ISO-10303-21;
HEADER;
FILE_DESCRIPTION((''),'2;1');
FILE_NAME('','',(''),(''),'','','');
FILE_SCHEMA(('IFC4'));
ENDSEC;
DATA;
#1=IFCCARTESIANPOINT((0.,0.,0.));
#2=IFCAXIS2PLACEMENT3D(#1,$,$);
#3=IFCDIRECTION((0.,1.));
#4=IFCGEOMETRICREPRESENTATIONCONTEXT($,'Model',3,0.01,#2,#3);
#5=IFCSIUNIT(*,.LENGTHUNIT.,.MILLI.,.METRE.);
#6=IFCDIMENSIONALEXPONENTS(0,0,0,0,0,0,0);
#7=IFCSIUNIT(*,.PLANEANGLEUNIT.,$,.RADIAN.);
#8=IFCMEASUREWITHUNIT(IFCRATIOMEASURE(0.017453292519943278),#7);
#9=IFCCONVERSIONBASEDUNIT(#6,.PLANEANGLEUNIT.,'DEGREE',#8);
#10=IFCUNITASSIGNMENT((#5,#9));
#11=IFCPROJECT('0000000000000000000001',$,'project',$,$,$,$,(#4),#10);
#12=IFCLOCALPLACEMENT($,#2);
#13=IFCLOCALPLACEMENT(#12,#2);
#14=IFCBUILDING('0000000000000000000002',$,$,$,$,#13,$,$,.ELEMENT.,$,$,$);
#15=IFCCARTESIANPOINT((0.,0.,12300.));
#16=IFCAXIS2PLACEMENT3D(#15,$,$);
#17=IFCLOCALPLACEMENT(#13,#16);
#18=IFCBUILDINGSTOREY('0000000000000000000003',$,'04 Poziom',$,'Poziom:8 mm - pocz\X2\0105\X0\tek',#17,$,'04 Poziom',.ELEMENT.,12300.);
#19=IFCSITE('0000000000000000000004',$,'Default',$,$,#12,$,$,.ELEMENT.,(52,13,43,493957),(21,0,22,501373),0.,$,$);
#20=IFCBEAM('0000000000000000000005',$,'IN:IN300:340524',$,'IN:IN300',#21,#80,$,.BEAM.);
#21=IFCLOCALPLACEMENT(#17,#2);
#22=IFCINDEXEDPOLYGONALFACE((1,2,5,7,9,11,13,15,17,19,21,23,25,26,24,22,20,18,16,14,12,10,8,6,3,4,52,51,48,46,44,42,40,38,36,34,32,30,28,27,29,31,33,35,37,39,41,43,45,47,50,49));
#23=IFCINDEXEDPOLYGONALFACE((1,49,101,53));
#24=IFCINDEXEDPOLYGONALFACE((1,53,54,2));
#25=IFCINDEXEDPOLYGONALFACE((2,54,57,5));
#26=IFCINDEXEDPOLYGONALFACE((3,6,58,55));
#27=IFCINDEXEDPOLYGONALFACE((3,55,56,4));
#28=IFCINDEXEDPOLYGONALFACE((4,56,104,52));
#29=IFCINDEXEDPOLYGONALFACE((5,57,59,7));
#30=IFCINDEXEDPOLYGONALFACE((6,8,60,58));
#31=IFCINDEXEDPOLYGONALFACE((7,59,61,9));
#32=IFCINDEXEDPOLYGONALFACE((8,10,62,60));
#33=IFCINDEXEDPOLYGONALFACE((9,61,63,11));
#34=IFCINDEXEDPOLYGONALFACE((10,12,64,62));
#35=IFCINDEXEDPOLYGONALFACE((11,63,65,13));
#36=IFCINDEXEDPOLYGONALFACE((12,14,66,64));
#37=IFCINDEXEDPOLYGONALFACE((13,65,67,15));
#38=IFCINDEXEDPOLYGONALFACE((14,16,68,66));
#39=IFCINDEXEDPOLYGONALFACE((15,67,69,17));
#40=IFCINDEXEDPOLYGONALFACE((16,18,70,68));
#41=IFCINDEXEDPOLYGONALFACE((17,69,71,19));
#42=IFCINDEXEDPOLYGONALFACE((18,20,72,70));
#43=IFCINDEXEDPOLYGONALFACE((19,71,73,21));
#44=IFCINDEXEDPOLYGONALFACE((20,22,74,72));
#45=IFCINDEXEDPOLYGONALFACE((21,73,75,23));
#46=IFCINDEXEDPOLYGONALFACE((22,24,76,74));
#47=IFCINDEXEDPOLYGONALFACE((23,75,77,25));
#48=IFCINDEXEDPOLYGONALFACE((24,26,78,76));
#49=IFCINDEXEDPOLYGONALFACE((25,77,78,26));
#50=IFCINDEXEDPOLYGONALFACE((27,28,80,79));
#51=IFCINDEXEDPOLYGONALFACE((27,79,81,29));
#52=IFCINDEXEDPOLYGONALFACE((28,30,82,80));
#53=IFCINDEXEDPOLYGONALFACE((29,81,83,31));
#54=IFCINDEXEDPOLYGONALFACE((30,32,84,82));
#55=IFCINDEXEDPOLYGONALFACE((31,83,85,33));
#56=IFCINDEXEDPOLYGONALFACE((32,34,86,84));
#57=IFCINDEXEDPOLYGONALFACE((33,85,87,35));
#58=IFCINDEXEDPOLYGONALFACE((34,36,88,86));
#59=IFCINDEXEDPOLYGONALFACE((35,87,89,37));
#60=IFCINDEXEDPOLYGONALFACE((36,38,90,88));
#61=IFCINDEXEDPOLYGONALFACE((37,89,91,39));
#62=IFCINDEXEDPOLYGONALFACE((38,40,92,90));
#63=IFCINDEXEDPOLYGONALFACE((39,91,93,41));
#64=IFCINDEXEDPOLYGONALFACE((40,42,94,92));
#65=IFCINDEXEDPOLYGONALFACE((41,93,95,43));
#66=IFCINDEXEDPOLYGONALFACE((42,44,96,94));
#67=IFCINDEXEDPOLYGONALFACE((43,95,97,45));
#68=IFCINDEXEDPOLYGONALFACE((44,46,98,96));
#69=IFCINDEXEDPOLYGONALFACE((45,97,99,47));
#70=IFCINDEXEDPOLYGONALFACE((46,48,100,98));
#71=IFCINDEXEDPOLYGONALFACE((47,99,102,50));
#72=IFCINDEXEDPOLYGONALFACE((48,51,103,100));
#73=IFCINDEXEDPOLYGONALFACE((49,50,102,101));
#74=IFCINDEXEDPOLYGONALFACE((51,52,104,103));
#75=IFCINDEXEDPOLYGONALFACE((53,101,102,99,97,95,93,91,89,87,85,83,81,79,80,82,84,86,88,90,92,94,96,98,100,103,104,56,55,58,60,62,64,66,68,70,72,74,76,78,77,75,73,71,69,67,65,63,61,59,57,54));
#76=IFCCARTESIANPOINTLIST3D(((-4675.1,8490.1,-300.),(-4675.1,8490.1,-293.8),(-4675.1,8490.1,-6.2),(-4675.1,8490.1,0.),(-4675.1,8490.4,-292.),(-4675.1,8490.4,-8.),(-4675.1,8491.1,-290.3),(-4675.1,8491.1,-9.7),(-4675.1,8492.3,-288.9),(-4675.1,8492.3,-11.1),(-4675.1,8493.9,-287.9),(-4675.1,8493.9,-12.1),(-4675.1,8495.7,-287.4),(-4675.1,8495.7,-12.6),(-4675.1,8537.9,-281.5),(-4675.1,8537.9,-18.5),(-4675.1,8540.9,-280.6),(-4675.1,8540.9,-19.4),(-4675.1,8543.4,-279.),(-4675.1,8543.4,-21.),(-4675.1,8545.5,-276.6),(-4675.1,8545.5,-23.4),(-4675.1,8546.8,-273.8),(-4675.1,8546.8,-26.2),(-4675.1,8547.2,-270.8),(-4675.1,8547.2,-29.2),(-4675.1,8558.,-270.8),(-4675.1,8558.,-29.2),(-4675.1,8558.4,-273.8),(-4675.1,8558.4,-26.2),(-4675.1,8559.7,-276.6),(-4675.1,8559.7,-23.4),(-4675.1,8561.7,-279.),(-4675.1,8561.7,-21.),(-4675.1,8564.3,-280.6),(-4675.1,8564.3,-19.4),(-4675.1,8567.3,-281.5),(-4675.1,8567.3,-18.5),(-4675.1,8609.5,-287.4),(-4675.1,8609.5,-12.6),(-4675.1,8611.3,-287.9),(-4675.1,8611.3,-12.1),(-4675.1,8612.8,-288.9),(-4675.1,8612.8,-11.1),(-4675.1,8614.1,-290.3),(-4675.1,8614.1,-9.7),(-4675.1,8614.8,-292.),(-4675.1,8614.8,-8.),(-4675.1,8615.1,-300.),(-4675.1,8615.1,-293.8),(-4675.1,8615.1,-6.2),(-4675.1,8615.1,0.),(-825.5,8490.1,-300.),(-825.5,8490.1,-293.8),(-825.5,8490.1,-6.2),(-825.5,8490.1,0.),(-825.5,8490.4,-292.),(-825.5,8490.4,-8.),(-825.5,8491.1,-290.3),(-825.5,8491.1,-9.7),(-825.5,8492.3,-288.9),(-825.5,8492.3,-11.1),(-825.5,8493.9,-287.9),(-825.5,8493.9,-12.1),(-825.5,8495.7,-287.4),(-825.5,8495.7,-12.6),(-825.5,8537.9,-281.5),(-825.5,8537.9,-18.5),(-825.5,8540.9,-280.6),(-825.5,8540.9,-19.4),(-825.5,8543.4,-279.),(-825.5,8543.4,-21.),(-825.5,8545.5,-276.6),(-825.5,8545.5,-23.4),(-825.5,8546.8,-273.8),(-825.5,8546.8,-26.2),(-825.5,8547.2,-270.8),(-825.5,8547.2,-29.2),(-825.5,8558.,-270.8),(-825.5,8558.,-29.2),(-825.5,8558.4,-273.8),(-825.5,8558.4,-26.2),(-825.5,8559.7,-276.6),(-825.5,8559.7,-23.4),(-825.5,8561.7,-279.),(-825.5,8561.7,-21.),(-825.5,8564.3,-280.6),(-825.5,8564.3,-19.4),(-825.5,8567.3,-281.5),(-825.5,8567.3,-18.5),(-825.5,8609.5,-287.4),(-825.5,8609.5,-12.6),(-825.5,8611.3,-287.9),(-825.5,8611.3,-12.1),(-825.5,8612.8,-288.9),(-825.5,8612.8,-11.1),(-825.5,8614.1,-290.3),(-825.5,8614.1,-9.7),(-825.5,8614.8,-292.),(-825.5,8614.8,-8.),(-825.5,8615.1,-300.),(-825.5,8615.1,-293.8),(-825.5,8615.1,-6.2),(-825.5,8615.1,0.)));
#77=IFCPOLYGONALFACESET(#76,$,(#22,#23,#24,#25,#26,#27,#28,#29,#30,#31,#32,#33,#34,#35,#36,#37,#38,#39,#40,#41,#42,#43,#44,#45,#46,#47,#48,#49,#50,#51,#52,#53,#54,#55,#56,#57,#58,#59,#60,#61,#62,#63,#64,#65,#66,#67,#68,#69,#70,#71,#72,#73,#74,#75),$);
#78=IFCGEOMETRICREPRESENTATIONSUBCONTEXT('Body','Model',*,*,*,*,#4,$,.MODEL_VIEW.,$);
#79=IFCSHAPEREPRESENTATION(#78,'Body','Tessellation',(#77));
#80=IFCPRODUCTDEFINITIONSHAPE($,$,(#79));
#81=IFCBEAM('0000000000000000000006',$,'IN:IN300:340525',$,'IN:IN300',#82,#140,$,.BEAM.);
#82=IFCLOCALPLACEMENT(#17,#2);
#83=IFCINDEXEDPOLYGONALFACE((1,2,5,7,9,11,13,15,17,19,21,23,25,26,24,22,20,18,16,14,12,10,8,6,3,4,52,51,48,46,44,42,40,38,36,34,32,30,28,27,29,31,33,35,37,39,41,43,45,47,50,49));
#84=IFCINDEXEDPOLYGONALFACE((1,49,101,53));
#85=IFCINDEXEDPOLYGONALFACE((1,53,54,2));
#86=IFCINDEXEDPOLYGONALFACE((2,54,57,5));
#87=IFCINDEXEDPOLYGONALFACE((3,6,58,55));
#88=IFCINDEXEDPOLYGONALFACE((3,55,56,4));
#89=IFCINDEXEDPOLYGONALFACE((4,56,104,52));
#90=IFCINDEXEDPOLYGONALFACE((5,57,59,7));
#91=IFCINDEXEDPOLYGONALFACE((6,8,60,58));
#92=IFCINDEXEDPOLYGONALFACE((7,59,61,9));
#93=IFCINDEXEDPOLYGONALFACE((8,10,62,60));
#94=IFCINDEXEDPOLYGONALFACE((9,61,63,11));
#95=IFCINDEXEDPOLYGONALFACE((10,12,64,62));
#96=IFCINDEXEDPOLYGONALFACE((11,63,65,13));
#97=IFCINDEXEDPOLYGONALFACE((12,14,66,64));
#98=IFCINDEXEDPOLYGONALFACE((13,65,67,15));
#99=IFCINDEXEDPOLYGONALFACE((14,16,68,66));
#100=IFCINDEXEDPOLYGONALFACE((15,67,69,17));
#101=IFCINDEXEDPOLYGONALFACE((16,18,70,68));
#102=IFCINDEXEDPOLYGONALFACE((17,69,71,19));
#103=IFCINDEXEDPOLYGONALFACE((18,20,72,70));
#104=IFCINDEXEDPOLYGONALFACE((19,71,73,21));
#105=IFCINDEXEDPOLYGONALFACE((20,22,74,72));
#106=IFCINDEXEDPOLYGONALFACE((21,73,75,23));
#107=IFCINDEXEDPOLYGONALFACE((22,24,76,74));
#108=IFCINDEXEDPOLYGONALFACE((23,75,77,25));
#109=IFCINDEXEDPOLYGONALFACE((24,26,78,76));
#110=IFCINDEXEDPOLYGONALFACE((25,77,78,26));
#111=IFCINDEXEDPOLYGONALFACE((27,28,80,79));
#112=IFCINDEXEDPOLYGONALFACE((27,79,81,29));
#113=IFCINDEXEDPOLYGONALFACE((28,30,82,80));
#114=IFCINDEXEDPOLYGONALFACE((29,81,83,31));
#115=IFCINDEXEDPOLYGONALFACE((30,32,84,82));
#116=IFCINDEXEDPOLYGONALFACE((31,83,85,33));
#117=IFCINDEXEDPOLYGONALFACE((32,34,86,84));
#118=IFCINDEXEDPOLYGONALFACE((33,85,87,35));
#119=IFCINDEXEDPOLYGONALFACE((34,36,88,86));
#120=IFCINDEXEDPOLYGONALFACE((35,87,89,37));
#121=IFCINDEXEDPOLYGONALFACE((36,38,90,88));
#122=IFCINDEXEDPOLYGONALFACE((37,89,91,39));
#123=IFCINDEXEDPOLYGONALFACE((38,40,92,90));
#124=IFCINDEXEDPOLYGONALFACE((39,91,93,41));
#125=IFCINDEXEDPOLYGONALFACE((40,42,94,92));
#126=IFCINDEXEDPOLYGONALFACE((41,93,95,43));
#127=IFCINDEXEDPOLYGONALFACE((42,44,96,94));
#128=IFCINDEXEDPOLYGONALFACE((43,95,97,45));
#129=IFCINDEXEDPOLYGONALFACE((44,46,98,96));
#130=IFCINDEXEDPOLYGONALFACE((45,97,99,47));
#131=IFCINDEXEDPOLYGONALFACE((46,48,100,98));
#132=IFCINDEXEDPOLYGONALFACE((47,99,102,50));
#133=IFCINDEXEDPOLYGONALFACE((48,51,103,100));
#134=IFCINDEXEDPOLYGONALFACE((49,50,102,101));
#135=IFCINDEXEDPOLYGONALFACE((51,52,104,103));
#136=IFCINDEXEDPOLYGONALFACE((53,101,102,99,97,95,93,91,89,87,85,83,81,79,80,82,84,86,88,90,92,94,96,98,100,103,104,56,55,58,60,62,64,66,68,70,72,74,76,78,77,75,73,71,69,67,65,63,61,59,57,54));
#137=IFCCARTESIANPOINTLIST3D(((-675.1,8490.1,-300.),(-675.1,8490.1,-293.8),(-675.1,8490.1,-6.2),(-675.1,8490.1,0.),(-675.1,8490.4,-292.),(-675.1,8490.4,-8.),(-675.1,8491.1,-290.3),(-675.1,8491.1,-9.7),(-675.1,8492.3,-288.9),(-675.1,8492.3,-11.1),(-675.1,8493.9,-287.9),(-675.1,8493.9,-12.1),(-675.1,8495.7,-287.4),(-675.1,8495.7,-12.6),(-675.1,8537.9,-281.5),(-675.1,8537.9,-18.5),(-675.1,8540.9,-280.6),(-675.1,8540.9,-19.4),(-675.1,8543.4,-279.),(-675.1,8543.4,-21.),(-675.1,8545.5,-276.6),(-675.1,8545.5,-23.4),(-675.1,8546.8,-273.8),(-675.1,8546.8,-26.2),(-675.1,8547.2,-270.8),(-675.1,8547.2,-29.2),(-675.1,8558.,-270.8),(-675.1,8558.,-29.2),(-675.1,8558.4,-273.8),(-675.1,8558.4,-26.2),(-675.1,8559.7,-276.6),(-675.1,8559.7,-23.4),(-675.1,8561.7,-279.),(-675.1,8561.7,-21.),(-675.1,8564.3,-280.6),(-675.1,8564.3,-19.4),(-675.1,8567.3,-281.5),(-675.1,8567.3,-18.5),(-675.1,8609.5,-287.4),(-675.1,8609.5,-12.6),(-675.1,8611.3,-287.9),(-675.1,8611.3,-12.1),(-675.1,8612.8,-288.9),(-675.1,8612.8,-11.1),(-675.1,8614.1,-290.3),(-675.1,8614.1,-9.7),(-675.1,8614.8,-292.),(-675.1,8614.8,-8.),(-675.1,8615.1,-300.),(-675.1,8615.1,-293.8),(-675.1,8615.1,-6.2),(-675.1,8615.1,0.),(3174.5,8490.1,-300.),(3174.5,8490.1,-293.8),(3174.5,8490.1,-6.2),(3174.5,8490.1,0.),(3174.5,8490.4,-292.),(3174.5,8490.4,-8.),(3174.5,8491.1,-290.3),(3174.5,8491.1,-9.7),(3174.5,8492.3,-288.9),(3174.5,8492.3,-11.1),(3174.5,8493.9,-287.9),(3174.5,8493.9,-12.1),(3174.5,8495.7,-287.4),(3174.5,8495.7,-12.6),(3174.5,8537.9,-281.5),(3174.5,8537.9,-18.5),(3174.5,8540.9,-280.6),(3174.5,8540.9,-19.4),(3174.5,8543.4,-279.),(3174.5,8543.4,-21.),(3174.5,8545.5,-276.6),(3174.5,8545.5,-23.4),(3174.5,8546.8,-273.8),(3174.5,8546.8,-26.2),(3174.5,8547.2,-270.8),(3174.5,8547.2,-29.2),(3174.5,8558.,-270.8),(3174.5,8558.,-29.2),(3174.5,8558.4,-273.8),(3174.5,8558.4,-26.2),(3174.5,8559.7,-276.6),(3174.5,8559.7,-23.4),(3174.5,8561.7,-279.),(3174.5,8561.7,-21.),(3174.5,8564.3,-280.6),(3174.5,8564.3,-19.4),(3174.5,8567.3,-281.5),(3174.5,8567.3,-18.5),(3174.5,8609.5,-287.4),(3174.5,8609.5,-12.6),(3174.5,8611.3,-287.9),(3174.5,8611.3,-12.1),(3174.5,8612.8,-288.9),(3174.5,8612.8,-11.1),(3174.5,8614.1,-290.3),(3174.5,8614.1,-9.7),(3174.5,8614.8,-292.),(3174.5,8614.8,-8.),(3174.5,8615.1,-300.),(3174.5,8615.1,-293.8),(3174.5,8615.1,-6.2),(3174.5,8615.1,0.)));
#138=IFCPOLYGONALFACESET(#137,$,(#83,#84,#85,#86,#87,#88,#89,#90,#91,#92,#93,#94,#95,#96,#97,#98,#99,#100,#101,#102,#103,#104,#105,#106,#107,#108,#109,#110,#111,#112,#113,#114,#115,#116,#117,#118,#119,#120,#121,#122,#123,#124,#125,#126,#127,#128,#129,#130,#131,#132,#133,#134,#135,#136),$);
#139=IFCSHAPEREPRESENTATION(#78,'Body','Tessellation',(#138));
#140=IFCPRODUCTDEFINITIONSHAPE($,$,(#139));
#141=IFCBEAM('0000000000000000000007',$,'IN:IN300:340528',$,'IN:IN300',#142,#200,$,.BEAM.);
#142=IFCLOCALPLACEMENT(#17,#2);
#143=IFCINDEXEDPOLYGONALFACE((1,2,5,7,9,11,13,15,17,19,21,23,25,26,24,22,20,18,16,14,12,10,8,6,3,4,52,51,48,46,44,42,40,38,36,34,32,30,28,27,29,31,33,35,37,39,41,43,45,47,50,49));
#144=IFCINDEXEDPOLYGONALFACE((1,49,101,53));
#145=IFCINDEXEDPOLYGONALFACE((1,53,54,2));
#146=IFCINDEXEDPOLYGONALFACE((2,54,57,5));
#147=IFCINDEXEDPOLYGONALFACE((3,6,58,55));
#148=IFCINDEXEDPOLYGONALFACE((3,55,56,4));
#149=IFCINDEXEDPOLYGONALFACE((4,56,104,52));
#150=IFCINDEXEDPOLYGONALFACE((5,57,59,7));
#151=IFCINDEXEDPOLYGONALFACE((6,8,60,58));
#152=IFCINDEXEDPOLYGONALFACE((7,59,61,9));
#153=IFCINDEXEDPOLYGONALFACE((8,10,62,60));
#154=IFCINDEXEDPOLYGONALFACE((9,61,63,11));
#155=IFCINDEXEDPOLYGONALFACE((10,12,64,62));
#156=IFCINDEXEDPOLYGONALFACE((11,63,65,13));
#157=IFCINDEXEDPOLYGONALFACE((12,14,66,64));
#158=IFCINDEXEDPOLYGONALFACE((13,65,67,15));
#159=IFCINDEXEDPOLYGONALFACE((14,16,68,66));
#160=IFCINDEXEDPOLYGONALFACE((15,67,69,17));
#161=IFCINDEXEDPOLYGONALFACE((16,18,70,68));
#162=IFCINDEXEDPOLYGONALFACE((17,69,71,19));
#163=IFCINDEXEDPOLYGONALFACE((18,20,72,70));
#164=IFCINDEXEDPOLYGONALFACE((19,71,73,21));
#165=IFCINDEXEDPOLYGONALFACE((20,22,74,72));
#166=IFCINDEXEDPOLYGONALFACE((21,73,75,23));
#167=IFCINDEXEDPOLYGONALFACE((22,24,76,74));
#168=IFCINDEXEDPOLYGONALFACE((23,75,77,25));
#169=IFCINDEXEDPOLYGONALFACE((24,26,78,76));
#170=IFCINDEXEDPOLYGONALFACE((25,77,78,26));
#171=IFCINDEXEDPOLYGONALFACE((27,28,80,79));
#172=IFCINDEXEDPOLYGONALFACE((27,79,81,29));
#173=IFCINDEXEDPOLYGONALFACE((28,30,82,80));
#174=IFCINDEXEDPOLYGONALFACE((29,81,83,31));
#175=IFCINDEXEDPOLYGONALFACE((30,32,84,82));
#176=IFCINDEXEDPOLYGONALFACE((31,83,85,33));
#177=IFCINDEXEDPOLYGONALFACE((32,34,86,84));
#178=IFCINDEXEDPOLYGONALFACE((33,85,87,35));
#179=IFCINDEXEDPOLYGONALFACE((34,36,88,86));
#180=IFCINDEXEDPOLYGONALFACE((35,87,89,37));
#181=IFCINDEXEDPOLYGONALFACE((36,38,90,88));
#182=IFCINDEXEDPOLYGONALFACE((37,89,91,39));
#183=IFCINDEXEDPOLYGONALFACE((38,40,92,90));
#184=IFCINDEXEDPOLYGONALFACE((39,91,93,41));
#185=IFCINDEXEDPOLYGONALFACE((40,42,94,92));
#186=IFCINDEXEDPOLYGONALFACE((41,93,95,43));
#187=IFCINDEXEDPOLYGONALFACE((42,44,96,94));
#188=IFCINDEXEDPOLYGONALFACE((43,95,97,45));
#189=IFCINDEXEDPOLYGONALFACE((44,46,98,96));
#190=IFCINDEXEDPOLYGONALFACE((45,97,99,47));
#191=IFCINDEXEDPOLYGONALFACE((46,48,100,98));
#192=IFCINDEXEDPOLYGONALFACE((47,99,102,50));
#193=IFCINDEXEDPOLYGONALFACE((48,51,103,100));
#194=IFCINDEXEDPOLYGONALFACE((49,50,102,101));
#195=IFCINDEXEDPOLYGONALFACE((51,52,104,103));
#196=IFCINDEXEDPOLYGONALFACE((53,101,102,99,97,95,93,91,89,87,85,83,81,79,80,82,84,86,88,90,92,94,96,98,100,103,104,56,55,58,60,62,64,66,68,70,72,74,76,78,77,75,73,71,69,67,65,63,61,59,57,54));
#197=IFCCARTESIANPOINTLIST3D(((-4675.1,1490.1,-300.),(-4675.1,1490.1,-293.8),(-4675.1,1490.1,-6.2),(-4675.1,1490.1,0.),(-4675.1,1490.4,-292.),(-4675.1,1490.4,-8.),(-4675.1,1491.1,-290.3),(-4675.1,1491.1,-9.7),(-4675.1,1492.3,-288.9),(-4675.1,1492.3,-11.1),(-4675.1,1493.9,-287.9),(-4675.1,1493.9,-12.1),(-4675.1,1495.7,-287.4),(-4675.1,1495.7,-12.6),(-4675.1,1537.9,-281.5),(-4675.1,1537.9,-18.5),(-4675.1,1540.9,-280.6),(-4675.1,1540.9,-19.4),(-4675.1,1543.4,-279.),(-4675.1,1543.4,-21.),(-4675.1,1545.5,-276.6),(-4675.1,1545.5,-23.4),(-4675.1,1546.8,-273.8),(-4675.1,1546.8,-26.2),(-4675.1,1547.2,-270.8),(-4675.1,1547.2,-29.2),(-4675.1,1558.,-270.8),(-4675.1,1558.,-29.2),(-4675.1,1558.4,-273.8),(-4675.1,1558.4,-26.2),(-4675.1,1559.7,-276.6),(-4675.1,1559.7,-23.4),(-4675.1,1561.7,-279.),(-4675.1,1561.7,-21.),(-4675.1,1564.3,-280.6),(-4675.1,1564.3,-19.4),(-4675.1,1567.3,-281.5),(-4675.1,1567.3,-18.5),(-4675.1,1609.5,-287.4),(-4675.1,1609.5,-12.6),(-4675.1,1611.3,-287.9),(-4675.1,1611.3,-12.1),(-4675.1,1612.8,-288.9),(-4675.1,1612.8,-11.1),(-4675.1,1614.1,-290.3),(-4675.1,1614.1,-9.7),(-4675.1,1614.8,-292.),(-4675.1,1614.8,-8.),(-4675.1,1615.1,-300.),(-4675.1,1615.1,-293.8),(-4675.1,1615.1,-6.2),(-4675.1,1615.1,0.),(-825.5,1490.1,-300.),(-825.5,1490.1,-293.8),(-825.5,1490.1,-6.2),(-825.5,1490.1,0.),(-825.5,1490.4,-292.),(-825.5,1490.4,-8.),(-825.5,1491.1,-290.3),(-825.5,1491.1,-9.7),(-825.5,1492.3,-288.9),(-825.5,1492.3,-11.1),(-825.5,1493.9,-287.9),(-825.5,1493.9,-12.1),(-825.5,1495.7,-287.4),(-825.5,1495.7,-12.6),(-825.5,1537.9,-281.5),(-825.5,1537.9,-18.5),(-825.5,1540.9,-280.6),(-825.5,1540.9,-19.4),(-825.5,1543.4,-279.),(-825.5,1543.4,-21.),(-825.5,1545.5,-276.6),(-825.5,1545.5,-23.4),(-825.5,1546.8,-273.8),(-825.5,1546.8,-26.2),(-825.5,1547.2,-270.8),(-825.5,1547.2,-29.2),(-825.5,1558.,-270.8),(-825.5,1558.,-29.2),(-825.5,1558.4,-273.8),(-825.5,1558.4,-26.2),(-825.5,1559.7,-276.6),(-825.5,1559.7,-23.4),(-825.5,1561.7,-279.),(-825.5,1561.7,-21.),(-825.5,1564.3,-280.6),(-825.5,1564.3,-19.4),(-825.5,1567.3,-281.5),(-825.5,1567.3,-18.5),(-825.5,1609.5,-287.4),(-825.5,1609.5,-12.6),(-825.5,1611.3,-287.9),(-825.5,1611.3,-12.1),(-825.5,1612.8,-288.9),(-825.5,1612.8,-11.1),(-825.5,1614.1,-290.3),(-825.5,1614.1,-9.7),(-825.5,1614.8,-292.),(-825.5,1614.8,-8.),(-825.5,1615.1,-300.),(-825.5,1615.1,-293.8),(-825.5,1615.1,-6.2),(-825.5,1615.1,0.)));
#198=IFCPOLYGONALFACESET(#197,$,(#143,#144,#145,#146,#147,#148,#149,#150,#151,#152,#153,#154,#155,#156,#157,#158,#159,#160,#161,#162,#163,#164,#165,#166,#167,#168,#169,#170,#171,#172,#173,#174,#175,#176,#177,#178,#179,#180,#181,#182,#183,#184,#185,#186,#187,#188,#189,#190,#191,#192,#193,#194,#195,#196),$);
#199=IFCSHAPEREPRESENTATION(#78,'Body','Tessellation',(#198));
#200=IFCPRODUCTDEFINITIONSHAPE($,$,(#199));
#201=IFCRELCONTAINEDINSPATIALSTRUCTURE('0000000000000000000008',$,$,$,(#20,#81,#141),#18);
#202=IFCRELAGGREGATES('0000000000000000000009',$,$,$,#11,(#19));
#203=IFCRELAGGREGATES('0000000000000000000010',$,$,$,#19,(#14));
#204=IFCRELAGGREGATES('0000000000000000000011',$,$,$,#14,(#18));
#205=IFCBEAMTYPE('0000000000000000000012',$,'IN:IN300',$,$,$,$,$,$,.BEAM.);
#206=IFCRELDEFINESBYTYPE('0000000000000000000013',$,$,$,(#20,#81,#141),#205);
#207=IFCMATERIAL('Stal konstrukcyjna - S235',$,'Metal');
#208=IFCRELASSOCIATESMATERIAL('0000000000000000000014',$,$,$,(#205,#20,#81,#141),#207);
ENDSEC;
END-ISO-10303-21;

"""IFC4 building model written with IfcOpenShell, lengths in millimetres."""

from ifc_helpers import new_model, entity, si_unit, converted_unit, direction, frame, origin, place, context, subcontext, project, spatial, line, arc, indexed_curve, outline, extrude, source, transform, mapped, material, type_object, type_shapes, element, save


model = new_model("IFC4")

# Units and contexts
model_context = context("Model", 3, precision=0.01, world=origin(), true_north=direction((0.0, 1.0)))
body_context = subcontext(model_context, "Body", "Model", "MODEL_VIEW")
ifc_project = project(units=[si_unit("LENGTHUNIT", "METRE", prefix="MILLI"), converted_unit("PLANEANGLEUNIT", "DEGREE", entity("IfcRatioMeasure", 0.017453292519943278), si_unit("PLANEANGLEUNIT", "RADIAN"), dimensions=[0, 0, 0, 0, 0, 0, 0])], contexts=[model_context])

# Site, building, storey
site_placement = place(None, origin())
site = spatial("IfcSite", under=ifc_project, at=site_placement, Name="Default", CompositionType="ELEMENT", RefLatitude=(52, 13, 43, 493957), RefLongitude=(21, 0, 22, 501373), RefElevation=0.0)
building_placement = place(site_placement, origin())
building = spatial("IfcBuilding", under=site, at=building_placement, CompositionType="ELEMENT")
storey_placement = place(building_placement, frame((0.0, 0.0, 12300.0)))
storey = spatial("IfcBuildingStorey", under=building, at=storey_placement, Name="04 Poziom", ObjectType="Poziom:8 mm - początek", LongName="04 Poziom", CompositionType="ELEMENT", Elevation=12300.0)

# Shared definitions
ifc_material_1 = material(Name="Stal konstrukcyjna - S235", Category="Metal")

# Beams
beam_type_1 = type_object("IfcBeamType", Name="IN:IN300", PredefinedType="BEAM", material=ifc_material_1)
shared_shape_1 = source(origin(), body_context, "Body", "SweptSolid", [
    extrude(outline(indexed_curve([(143.8, -62.5), (150.0, -62.5), (150.0, 62.5), (143.8, 62.5), (139.6, 60.9), (137.4, 56.9), (131.5, 14.7), (127.9, 8.1), (120.8, 5.4), (-120.8, 5.4), (-127.9, 8.1), (-131.5, 14.7), (-137.4, 56.9), (-139.6, 60.9), (-143.8, 62.5), (-150.0, 62.5), (-150.0, -62.5), (-143.8, -62.5), (-139.6, -60.9), (-137.4, -56.9), (-131.5, -14.7), (-127.9, -8.1), (-120.8, -5.4), (120.8, -5.4), (127.9, -8.1), (131.5, -14.7), (137.4, -56.9), (139.6, -60.9)], segments=[line(1, 2, 3, 4), arc(4, 5, 6), line(6, 7), arc(7, 8, 9), line(9, 10), arc(10, 11, 12), line(12, 13), arc(13, 14, 15), line(15, 16, 17, 18), arc(18, 19, 20), line(20, 21), arc(21, 22, 23), line(23, 24), arc(24, 25, 26), line(26, 27), arc(27, 28, 1)], self_intersect=False)), frame((-1924.8, 0.0, 0.0), z_axis=(1.0, 0.0, 0.0), x_axis=(0.0, 0.0, -1.0)), (0.0, 0.0, 1.0), 3849.6),
])
type_shapes(beam_type_1, [shared_shape_1])
for number, where, name in (
    (1, (-2750.3, 8552.6, -150.0), "IN:IN300:340524"),
    (2, (1249.7, 8552.6, -150.0), "IN:IN300:340525"),
    (3, (-2750.3, 1552.6, -150.0), "IN:IN300:340528"),
):
    element("IfcBeam", number, at=place(storey_placement, frame(where)), inside=storey, type_object=beam_type_1, material=ifc_material_1, Name=name, ObjectType="IN:IN300", PredefinedType="BEAM", context=body_context, shape_type="MappedRepresentation", body=[
        mapped(shared_shape_1, transform((0.0, 0.0, 0.0), scale=1.0)),
    ])

save(model, "model.ifc")
